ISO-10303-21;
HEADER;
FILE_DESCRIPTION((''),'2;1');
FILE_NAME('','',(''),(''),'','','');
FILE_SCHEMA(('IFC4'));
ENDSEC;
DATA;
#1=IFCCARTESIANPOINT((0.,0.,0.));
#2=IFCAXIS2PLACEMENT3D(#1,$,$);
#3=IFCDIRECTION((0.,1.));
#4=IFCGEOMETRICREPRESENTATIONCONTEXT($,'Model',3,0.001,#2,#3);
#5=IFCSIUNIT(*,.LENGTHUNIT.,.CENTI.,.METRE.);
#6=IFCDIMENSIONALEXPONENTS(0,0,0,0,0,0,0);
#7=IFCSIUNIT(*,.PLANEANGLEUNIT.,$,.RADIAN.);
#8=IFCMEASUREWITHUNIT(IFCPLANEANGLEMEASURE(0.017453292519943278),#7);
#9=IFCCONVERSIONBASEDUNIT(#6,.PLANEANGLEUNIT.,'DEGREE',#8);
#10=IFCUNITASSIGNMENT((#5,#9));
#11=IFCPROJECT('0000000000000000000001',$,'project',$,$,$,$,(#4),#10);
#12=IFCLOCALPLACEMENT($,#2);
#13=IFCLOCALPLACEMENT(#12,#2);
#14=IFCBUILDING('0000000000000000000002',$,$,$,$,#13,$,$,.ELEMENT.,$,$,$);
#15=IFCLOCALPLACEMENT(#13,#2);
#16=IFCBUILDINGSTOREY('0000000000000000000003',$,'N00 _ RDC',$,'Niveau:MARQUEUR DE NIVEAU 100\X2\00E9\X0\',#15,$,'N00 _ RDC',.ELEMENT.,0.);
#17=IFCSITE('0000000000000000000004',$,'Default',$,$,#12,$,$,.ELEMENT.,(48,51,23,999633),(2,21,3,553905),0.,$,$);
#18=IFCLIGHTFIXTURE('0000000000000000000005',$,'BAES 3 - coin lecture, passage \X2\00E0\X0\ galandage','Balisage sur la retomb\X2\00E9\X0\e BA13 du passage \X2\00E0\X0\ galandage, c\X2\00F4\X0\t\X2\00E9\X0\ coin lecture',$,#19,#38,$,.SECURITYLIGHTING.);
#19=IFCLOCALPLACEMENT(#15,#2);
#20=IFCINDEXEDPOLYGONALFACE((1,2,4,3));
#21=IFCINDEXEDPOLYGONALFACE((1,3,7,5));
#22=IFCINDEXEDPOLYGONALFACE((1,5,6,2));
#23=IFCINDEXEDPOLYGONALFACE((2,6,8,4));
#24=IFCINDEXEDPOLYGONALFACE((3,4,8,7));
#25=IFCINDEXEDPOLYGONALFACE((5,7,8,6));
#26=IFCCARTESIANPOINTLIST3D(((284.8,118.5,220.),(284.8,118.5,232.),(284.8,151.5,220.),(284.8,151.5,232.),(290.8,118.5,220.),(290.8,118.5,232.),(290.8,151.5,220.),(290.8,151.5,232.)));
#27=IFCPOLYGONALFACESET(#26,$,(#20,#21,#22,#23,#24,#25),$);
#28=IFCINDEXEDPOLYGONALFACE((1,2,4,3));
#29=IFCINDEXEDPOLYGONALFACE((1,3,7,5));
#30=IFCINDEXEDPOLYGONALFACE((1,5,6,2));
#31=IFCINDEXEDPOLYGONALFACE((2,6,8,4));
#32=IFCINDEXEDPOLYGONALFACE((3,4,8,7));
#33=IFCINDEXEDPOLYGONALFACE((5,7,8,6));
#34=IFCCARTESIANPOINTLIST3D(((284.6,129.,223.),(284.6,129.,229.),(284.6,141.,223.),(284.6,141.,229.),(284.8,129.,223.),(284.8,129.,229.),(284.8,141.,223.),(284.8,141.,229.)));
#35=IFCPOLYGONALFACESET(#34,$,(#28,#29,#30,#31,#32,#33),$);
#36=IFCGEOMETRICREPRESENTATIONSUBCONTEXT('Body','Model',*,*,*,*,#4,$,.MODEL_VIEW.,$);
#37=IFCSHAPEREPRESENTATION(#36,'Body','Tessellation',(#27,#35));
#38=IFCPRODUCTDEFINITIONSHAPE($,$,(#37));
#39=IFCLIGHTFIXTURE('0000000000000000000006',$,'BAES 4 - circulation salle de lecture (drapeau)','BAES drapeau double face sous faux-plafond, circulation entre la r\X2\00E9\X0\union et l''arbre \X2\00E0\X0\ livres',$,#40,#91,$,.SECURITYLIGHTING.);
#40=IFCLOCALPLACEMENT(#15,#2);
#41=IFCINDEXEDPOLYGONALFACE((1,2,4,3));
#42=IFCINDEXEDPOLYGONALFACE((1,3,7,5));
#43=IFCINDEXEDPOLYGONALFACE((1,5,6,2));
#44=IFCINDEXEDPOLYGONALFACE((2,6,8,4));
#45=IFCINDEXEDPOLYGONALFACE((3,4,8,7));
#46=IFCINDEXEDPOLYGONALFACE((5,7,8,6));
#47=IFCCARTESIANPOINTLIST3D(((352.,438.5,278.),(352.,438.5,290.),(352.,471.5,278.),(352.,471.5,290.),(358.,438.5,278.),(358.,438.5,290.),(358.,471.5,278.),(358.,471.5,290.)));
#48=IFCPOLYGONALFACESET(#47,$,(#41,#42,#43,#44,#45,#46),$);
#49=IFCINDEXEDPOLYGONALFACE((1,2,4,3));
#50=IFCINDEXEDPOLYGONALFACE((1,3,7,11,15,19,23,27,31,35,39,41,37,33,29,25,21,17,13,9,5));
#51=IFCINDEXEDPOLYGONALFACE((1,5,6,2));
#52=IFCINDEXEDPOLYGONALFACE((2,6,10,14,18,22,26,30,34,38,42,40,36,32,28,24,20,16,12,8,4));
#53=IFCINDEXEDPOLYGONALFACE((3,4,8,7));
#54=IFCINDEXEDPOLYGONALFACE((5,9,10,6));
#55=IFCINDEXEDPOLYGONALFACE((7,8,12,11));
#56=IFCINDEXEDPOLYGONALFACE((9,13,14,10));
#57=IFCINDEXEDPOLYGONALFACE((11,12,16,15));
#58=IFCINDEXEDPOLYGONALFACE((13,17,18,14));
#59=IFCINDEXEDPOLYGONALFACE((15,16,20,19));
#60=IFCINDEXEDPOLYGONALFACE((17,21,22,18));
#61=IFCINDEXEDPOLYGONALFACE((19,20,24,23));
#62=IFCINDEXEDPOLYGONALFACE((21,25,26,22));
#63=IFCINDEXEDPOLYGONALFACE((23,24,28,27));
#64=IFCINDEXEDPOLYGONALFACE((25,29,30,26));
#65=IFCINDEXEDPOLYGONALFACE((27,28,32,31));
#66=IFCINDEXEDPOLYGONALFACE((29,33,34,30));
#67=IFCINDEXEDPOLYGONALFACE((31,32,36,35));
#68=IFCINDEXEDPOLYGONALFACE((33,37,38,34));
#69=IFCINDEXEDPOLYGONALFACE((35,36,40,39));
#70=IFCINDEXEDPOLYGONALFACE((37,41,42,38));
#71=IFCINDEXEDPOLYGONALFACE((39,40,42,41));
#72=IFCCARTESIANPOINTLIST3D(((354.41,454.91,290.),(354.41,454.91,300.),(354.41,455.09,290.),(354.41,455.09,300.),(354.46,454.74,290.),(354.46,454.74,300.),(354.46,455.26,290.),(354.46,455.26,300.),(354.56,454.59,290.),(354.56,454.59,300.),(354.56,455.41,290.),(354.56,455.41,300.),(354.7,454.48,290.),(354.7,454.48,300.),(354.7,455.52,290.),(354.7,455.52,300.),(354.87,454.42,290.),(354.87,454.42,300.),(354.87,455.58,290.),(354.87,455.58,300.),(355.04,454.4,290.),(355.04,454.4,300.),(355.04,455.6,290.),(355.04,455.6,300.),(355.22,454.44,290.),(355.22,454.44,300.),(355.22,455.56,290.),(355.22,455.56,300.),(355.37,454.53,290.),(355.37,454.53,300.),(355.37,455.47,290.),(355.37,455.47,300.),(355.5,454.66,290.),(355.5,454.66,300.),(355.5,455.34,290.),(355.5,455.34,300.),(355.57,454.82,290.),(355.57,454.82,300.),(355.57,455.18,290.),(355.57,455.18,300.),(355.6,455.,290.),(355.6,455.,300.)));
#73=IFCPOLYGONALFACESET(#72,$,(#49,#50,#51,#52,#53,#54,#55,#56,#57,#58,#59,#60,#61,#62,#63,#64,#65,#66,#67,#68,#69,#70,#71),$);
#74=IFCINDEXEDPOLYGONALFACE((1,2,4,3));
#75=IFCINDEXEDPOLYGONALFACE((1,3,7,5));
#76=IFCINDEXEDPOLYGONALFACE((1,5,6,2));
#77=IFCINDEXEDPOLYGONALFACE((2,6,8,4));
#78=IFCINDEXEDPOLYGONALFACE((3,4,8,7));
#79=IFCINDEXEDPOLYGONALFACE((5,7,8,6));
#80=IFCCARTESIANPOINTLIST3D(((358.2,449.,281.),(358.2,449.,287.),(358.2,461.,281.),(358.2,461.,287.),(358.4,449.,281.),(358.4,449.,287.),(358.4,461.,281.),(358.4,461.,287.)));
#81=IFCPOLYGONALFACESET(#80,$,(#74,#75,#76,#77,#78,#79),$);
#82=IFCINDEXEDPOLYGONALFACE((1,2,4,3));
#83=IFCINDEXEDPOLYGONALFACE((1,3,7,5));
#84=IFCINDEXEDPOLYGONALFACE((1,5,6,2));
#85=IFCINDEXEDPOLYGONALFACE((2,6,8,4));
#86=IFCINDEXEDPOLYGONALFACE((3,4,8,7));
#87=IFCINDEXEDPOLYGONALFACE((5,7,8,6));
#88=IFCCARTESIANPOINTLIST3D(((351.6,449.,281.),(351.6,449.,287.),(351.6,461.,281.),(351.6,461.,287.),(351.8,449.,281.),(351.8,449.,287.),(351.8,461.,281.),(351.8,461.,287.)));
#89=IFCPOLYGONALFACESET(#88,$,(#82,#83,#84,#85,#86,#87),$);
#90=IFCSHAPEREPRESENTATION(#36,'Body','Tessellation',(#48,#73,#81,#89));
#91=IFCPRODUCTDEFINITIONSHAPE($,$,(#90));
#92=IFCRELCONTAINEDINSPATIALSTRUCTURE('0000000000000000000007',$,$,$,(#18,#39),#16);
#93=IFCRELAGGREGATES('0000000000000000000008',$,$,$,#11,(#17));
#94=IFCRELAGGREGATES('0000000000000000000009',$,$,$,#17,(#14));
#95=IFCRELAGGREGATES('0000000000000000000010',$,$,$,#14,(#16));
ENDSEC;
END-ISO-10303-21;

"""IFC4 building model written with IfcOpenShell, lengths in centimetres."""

from ifc_helpers import new_model, entity, si_unit, converted_unit, direction, frame, frame_2d, origin, origin_with_axes, place, context, subcontext, project, spatial, rectangle, circle, extrude, element, save


model = new_model("IFC4")

# Units and contexts
model_context = context("Model", 3, precision=0.001, world=origin(), true_north=direction((0.0, 1.0)))
body_context = subcontext(model_context, "Body", "Model", "MODEL_VIEW")
ifc_project = project(units=[si_unit("LENGTHUNIT", "METRE", prefix="CENTI"), converted_unit("PLANEANGLEUNIT", "DEGREE", entity("IfcPlaneAngleMeasure", 0.017453292519943278), si_unit("PLANEANGLEUNIT", "RADIAN"), dimensions=[0, 0, 0, 0, 0, 0, 0])], contexts=[model_context])

# Site, building, storey
site_placement = place(None, origin())
site = spatial("IfcSite", under=ifc_project, at=site_placement, Name="Default", CompositionType="ELEMENT", RefLatitude=(48, 51, 23, 999633), RefLongitude=(2, 21, 3, 553905), RefElevation=0.0)
building_placement = place(site_placement, origin())
building = spatial("IfcBuilding", under=site, at=building_placement, CompositionType="ELEMENT")
storey_placement = place(building_placement, origin())
storey = spatial("IfcBuildingStorey", under=building, at=storey_placement, Name="N00 _ RDC", ObjectType="Niveau:MARQUEUR DE NIVEAU 100é", LongName="N00 _ RDC", CompositionType="ELEMENT", Elevation=0.0)

# Light fixtures
light_fixture_1_placement = place(storey_placement, origin_with_axes())
element("IfcLightFixture", 1, at=light_fixture_1_placement, inside=storey, Name="BAES 3 - coin lecture, passage à galandage", Description="Balisage sur la retombée BA13 du passage à galandage, côté coin lecture", PredefinedType="SECURITYLIGHTING", context=body_context, shape_type="SweptSolid", body=[
    extrude(rectangle(XDim=6.0, YDim=33.0, at=frame_2d((287.8, 135.0))), frame((0.0, 0.0, 220.0)), (0.0, 0.0, 1.0), 12.0),
    extrude(rectangle(XDim=0.2, YDim=12.0, at=frame_2d((284.7, 135.0))), frame((0.0, 0.0, 223.0)), (0.0, 0.0, 1.0), 6.0),
])
light_fixture_2_placement = place(storey_placement, origin_with_axes())
element("IfcLightFixture", 2, at=light_fixture_2_placement, inside=storey, Name="BAES 4 - circulation salle de lecture (drapeau)", Description="BAES drapeau double face sous faux-plafond, circulation entre la réunion et l'arbre à livres", PredefinedType="SECURITYLIGHTING", context=body_context, shape_type="SweptSolid", body=[
    extrude(rectangle(XDim=6.0, YDim=33.0, at=frame_2d((355.0, 455.0))), frame((0.0, 0.0, 278.0)), (0.0, 0.0, 1.0), 12.0),
    extrude(circle(Radius=0.6, at=frame_2d((355.0, 455.0))), frame((0.0, 0.0, 290.0)), (0.0, 0.0, 1.0), 10.0),
    extrude(rectangle(XDim=0.2, YDim=12.0, at=frame_2d((358.3, 455.0))), frame((0.0, 0.0, 281.0)), (0.0, 0.0, 1.0), 6.0),
    extrude(rectangle(XDim=0.2, YDim=12.0, at=frame_2d((351.7, 455.0))), frame((0.0, 0.0, 281.0)), (0.0, 0.0, 1.0), 6.0),
])

save(model, "model.ifc")
